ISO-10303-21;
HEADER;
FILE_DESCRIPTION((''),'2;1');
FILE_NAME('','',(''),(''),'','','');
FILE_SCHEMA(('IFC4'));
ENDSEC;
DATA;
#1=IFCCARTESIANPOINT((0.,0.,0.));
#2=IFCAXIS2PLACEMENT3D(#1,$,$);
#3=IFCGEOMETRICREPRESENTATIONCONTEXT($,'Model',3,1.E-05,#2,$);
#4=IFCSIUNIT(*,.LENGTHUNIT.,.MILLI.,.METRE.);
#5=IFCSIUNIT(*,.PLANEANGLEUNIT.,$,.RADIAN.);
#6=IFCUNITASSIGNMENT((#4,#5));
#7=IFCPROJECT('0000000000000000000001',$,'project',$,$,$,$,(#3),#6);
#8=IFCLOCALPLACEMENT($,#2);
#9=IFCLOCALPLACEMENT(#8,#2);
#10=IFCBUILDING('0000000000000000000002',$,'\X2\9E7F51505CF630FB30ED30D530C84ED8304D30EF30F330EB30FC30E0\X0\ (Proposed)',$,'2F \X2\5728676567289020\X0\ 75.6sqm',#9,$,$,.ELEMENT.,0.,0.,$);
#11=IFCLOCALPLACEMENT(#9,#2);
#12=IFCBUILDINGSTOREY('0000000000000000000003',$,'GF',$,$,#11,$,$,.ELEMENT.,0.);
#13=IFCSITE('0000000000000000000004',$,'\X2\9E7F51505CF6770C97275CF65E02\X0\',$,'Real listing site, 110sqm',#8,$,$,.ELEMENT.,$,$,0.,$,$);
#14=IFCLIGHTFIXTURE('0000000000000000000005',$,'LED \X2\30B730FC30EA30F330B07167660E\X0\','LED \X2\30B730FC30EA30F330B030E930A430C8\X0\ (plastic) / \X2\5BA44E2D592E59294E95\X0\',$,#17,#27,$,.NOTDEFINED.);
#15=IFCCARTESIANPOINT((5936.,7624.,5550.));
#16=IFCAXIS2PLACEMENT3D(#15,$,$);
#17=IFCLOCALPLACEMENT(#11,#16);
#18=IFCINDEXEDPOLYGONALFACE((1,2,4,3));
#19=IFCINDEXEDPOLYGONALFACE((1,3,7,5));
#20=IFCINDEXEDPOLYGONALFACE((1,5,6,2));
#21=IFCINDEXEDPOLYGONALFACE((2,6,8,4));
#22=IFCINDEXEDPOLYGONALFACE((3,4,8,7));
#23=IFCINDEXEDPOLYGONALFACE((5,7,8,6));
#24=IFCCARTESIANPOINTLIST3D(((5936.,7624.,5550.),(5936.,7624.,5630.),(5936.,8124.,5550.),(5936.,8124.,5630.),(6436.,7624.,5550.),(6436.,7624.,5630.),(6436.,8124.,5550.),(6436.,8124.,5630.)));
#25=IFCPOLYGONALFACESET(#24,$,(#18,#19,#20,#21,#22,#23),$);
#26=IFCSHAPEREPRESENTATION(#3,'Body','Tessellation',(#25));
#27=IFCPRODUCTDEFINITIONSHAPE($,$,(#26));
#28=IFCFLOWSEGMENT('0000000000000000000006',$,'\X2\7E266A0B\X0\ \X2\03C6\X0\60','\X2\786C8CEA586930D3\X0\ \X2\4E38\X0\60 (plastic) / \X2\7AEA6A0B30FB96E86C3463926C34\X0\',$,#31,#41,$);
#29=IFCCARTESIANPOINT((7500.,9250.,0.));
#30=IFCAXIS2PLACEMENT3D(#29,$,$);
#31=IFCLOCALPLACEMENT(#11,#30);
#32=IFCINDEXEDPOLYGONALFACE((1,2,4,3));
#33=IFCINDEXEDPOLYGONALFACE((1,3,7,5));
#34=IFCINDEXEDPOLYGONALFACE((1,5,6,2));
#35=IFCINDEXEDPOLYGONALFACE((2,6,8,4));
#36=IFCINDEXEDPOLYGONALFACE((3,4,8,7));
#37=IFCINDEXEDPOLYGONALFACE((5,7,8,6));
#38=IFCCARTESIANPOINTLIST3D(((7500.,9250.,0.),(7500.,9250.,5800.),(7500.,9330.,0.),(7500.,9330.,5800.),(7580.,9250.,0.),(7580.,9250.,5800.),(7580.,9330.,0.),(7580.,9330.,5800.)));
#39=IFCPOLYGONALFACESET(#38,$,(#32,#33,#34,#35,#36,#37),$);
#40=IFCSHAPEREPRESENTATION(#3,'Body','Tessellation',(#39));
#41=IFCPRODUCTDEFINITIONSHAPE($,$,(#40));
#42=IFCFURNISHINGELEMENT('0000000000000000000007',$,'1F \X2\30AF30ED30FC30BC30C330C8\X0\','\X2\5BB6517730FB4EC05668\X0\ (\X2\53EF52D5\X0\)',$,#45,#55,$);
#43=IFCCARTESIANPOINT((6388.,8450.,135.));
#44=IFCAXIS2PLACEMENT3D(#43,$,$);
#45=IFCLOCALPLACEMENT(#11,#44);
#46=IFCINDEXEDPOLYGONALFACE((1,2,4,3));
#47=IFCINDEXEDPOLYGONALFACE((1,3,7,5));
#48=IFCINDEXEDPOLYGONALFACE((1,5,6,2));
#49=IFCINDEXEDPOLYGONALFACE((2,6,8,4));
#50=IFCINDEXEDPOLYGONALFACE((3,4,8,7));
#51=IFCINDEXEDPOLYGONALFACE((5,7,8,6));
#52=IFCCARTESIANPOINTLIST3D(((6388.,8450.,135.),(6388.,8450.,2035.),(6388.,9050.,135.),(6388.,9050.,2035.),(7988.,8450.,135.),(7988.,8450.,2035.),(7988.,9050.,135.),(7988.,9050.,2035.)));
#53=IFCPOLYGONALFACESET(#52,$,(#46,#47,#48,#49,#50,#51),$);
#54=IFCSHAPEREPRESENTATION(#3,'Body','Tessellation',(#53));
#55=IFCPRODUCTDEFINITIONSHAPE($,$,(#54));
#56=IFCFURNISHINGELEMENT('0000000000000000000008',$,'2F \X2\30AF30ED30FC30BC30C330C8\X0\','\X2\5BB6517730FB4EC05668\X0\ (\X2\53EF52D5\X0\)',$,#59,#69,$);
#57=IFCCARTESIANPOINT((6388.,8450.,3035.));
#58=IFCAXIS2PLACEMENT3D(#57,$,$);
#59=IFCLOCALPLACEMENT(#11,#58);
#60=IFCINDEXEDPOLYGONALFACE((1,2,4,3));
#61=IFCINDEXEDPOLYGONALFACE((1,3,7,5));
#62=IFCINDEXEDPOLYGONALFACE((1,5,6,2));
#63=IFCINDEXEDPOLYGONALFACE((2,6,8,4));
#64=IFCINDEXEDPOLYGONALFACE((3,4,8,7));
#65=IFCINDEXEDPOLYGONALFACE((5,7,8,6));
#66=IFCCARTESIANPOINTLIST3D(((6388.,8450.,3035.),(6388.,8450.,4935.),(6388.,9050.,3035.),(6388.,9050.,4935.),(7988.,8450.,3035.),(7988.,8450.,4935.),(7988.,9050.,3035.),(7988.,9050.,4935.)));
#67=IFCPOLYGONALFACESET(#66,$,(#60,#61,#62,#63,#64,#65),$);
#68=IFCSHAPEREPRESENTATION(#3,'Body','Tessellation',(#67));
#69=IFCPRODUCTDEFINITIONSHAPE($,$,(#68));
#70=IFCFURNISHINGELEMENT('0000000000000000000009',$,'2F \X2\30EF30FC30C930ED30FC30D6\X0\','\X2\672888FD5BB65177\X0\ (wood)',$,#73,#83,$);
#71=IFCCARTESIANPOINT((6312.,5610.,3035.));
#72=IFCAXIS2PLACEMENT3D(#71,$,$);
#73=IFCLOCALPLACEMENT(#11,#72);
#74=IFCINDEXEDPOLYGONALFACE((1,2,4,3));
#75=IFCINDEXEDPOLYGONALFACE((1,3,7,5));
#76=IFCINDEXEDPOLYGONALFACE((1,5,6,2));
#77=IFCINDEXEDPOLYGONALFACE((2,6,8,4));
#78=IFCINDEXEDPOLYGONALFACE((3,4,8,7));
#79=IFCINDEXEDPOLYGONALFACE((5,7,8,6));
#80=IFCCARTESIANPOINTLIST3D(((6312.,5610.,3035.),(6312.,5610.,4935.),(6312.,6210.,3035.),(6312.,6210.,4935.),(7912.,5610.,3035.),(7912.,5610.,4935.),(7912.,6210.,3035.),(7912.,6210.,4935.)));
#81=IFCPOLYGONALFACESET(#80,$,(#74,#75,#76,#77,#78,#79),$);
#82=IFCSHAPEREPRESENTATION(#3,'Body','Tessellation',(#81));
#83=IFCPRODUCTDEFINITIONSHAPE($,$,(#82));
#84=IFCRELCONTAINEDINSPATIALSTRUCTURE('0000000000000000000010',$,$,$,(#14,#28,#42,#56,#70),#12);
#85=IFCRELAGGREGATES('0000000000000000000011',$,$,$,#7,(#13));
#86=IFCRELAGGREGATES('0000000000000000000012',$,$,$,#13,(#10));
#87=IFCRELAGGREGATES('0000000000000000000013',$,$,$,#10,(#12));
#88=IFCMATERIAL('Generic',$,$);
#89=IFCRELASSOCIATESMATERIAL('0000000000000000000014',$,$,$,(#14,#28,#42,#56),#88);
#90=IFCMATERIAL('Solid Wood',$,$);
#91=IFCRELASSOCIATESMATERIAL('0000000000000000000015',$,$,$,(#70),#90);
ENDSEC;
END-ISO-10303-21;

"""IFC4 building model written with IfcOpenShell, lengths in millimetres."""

from ifc_helpers import new_model, si_unit, frame, frame_2d, origin, place, context, project, spatial, rectangle, extrude, material, element, save


model = new_model("IFC4")

# Units and contexts
model_context = context("Model", 3, precision=1e-05, world=origin())
ifc_project = project(units=[si_unit("LENGTHUNIT", "METRE", prefix="MILLI"), si_unit("PLANEANGLEUNIT", "RADIAN")], contexts=[model_context])

# Site, building, storey
site_placement = place(None, origin())
site = spatial("IfcSite", under=ifc_project, at=site_placement, Name="鹿児島県霧島市", ObjectType="Real listing site, 110sqm", CompositionType="ELEMENT", RefElevation=0.0)
building_placement = place(site_placement, origin())
building = spatial("IfcBuilding", under=site, at=building_placement, Name="鹿児島・ロフト付きワンルーム (Proposed)", ObjectType="2F 在来木造 75.6sqm", CompositionType="ELEMENT", ElevationOfRefHeight=0.0, ElevationOfTerrain=0.0)
storey_placement = place(building_placement, origin())
storey = spatial("IfcBuildingStorey", under=building, at=storey_placement, Name="GF", CompositionType="ELEMENT", Elevation=0.0)

# Shared definitions
ifc_material_1 = material(Name="Solid Wood")

# Shared definitions
ifc_material_2 = material(Name="Generic")

# Light fixture
light_fixture_1_placement = place(storey_placement, frame((5936.0, 7624.0, 5550.0)))
element("IfcLightFixture", 1, at=light_fixture_1_placement, inside=storey, material=ifc_material_2, Name="LED シーリング照明", Description="LED シーリングライト (plastic) / 室中央天井", PredefinedType="NOTDEFINED", context=model_context, shape_type="SweptSolid", body=[
    extrude(rectangle(XDim=500.0, YDim=500.0, at=frame_2d((250.0, 250.0))), frame((5936.0, 7624.0, 5550.0)), (0.0, 0.0, 1.0), 80.0),
])

# Flow segment
flow_segment_placement = place(storey_placement, frame((7500.0, 9250.0, 0.0)))
element("IfcFlowSegment", 2, at=flow_segment_placement, inside=storey, material=ifc_material_2, Name="縦樋 φ60", Description="硬質塩ビ 丸60 (plastic) / 竪樋・雨水排水", context=model_context, shape_type="SweptSolid", body=[
    extrude(rectangle(XDim=80.0, YDim=80.0, at=frame_2d((40.0, 40.0))), frame((7500.0, 9250.0, 0.0)), (0.0, 0.0, 1.0), 5800.0),
])

# Furnishing elements
furnishing_1_placement = place(storey_placement, frame((6388.0, 8450.0, 135.0)))
element("IfcFurnishingElement", 3, at=furnishing_1_placement, inside=storey, material=ifc_material_2, Name="1F クローゼット", Description="家具・什器 (可動)", context=model_context, shape_type="SweptSolid", body=[
    extrude(rectangle(XDim=1600.0, YDim=600.0, at=frame_2d((800.0, 300.0))), frame((6388.0, 8450.0, 135.0)), (0.0, 0.0, 1.0), 1900.0),
])
furnishing_2_placement = place(storey_placement, frame((6388.0, 8450.0, 3035.0)))
element("IfcFurnishingElement", 4, at=furnishing_2_placement, inside=storey, material=ifc_material_2, Name="2F クローゼット", Description="家具・什器 (可動)", context=model_context, shape_type="SweptSolid", body=[
    extrude(rectangle(XDim=1600.0, YDim=600.0, at=frame_2d((800.0, 300.0))), frame((6388.0, 8450.0, 3035.0)), (0.0, 0.0, 1.0), 1900.0),
])
furnishing_3_placement = place(storey_placement, frame((6312.0, 5610.0, 3035.0)))
element("IfcFurnishingElement", 5, at=furnishing_3_placement, inside=storey, material=ifc_material_1, Name="2F ワードローブ", Description="木製家具 (wood)", context=model_context, shape_type="SweptSolid", body=[
    extrude(rectangle(XDim=1600.0, YDim=600.0, at=frame_2d((800.0, 300.0))), frame((6312.0, 5610.0, 3035.0)), (0.0, 0.0, 1.0), 1900.0),
])

save(model, "model.ifc")
